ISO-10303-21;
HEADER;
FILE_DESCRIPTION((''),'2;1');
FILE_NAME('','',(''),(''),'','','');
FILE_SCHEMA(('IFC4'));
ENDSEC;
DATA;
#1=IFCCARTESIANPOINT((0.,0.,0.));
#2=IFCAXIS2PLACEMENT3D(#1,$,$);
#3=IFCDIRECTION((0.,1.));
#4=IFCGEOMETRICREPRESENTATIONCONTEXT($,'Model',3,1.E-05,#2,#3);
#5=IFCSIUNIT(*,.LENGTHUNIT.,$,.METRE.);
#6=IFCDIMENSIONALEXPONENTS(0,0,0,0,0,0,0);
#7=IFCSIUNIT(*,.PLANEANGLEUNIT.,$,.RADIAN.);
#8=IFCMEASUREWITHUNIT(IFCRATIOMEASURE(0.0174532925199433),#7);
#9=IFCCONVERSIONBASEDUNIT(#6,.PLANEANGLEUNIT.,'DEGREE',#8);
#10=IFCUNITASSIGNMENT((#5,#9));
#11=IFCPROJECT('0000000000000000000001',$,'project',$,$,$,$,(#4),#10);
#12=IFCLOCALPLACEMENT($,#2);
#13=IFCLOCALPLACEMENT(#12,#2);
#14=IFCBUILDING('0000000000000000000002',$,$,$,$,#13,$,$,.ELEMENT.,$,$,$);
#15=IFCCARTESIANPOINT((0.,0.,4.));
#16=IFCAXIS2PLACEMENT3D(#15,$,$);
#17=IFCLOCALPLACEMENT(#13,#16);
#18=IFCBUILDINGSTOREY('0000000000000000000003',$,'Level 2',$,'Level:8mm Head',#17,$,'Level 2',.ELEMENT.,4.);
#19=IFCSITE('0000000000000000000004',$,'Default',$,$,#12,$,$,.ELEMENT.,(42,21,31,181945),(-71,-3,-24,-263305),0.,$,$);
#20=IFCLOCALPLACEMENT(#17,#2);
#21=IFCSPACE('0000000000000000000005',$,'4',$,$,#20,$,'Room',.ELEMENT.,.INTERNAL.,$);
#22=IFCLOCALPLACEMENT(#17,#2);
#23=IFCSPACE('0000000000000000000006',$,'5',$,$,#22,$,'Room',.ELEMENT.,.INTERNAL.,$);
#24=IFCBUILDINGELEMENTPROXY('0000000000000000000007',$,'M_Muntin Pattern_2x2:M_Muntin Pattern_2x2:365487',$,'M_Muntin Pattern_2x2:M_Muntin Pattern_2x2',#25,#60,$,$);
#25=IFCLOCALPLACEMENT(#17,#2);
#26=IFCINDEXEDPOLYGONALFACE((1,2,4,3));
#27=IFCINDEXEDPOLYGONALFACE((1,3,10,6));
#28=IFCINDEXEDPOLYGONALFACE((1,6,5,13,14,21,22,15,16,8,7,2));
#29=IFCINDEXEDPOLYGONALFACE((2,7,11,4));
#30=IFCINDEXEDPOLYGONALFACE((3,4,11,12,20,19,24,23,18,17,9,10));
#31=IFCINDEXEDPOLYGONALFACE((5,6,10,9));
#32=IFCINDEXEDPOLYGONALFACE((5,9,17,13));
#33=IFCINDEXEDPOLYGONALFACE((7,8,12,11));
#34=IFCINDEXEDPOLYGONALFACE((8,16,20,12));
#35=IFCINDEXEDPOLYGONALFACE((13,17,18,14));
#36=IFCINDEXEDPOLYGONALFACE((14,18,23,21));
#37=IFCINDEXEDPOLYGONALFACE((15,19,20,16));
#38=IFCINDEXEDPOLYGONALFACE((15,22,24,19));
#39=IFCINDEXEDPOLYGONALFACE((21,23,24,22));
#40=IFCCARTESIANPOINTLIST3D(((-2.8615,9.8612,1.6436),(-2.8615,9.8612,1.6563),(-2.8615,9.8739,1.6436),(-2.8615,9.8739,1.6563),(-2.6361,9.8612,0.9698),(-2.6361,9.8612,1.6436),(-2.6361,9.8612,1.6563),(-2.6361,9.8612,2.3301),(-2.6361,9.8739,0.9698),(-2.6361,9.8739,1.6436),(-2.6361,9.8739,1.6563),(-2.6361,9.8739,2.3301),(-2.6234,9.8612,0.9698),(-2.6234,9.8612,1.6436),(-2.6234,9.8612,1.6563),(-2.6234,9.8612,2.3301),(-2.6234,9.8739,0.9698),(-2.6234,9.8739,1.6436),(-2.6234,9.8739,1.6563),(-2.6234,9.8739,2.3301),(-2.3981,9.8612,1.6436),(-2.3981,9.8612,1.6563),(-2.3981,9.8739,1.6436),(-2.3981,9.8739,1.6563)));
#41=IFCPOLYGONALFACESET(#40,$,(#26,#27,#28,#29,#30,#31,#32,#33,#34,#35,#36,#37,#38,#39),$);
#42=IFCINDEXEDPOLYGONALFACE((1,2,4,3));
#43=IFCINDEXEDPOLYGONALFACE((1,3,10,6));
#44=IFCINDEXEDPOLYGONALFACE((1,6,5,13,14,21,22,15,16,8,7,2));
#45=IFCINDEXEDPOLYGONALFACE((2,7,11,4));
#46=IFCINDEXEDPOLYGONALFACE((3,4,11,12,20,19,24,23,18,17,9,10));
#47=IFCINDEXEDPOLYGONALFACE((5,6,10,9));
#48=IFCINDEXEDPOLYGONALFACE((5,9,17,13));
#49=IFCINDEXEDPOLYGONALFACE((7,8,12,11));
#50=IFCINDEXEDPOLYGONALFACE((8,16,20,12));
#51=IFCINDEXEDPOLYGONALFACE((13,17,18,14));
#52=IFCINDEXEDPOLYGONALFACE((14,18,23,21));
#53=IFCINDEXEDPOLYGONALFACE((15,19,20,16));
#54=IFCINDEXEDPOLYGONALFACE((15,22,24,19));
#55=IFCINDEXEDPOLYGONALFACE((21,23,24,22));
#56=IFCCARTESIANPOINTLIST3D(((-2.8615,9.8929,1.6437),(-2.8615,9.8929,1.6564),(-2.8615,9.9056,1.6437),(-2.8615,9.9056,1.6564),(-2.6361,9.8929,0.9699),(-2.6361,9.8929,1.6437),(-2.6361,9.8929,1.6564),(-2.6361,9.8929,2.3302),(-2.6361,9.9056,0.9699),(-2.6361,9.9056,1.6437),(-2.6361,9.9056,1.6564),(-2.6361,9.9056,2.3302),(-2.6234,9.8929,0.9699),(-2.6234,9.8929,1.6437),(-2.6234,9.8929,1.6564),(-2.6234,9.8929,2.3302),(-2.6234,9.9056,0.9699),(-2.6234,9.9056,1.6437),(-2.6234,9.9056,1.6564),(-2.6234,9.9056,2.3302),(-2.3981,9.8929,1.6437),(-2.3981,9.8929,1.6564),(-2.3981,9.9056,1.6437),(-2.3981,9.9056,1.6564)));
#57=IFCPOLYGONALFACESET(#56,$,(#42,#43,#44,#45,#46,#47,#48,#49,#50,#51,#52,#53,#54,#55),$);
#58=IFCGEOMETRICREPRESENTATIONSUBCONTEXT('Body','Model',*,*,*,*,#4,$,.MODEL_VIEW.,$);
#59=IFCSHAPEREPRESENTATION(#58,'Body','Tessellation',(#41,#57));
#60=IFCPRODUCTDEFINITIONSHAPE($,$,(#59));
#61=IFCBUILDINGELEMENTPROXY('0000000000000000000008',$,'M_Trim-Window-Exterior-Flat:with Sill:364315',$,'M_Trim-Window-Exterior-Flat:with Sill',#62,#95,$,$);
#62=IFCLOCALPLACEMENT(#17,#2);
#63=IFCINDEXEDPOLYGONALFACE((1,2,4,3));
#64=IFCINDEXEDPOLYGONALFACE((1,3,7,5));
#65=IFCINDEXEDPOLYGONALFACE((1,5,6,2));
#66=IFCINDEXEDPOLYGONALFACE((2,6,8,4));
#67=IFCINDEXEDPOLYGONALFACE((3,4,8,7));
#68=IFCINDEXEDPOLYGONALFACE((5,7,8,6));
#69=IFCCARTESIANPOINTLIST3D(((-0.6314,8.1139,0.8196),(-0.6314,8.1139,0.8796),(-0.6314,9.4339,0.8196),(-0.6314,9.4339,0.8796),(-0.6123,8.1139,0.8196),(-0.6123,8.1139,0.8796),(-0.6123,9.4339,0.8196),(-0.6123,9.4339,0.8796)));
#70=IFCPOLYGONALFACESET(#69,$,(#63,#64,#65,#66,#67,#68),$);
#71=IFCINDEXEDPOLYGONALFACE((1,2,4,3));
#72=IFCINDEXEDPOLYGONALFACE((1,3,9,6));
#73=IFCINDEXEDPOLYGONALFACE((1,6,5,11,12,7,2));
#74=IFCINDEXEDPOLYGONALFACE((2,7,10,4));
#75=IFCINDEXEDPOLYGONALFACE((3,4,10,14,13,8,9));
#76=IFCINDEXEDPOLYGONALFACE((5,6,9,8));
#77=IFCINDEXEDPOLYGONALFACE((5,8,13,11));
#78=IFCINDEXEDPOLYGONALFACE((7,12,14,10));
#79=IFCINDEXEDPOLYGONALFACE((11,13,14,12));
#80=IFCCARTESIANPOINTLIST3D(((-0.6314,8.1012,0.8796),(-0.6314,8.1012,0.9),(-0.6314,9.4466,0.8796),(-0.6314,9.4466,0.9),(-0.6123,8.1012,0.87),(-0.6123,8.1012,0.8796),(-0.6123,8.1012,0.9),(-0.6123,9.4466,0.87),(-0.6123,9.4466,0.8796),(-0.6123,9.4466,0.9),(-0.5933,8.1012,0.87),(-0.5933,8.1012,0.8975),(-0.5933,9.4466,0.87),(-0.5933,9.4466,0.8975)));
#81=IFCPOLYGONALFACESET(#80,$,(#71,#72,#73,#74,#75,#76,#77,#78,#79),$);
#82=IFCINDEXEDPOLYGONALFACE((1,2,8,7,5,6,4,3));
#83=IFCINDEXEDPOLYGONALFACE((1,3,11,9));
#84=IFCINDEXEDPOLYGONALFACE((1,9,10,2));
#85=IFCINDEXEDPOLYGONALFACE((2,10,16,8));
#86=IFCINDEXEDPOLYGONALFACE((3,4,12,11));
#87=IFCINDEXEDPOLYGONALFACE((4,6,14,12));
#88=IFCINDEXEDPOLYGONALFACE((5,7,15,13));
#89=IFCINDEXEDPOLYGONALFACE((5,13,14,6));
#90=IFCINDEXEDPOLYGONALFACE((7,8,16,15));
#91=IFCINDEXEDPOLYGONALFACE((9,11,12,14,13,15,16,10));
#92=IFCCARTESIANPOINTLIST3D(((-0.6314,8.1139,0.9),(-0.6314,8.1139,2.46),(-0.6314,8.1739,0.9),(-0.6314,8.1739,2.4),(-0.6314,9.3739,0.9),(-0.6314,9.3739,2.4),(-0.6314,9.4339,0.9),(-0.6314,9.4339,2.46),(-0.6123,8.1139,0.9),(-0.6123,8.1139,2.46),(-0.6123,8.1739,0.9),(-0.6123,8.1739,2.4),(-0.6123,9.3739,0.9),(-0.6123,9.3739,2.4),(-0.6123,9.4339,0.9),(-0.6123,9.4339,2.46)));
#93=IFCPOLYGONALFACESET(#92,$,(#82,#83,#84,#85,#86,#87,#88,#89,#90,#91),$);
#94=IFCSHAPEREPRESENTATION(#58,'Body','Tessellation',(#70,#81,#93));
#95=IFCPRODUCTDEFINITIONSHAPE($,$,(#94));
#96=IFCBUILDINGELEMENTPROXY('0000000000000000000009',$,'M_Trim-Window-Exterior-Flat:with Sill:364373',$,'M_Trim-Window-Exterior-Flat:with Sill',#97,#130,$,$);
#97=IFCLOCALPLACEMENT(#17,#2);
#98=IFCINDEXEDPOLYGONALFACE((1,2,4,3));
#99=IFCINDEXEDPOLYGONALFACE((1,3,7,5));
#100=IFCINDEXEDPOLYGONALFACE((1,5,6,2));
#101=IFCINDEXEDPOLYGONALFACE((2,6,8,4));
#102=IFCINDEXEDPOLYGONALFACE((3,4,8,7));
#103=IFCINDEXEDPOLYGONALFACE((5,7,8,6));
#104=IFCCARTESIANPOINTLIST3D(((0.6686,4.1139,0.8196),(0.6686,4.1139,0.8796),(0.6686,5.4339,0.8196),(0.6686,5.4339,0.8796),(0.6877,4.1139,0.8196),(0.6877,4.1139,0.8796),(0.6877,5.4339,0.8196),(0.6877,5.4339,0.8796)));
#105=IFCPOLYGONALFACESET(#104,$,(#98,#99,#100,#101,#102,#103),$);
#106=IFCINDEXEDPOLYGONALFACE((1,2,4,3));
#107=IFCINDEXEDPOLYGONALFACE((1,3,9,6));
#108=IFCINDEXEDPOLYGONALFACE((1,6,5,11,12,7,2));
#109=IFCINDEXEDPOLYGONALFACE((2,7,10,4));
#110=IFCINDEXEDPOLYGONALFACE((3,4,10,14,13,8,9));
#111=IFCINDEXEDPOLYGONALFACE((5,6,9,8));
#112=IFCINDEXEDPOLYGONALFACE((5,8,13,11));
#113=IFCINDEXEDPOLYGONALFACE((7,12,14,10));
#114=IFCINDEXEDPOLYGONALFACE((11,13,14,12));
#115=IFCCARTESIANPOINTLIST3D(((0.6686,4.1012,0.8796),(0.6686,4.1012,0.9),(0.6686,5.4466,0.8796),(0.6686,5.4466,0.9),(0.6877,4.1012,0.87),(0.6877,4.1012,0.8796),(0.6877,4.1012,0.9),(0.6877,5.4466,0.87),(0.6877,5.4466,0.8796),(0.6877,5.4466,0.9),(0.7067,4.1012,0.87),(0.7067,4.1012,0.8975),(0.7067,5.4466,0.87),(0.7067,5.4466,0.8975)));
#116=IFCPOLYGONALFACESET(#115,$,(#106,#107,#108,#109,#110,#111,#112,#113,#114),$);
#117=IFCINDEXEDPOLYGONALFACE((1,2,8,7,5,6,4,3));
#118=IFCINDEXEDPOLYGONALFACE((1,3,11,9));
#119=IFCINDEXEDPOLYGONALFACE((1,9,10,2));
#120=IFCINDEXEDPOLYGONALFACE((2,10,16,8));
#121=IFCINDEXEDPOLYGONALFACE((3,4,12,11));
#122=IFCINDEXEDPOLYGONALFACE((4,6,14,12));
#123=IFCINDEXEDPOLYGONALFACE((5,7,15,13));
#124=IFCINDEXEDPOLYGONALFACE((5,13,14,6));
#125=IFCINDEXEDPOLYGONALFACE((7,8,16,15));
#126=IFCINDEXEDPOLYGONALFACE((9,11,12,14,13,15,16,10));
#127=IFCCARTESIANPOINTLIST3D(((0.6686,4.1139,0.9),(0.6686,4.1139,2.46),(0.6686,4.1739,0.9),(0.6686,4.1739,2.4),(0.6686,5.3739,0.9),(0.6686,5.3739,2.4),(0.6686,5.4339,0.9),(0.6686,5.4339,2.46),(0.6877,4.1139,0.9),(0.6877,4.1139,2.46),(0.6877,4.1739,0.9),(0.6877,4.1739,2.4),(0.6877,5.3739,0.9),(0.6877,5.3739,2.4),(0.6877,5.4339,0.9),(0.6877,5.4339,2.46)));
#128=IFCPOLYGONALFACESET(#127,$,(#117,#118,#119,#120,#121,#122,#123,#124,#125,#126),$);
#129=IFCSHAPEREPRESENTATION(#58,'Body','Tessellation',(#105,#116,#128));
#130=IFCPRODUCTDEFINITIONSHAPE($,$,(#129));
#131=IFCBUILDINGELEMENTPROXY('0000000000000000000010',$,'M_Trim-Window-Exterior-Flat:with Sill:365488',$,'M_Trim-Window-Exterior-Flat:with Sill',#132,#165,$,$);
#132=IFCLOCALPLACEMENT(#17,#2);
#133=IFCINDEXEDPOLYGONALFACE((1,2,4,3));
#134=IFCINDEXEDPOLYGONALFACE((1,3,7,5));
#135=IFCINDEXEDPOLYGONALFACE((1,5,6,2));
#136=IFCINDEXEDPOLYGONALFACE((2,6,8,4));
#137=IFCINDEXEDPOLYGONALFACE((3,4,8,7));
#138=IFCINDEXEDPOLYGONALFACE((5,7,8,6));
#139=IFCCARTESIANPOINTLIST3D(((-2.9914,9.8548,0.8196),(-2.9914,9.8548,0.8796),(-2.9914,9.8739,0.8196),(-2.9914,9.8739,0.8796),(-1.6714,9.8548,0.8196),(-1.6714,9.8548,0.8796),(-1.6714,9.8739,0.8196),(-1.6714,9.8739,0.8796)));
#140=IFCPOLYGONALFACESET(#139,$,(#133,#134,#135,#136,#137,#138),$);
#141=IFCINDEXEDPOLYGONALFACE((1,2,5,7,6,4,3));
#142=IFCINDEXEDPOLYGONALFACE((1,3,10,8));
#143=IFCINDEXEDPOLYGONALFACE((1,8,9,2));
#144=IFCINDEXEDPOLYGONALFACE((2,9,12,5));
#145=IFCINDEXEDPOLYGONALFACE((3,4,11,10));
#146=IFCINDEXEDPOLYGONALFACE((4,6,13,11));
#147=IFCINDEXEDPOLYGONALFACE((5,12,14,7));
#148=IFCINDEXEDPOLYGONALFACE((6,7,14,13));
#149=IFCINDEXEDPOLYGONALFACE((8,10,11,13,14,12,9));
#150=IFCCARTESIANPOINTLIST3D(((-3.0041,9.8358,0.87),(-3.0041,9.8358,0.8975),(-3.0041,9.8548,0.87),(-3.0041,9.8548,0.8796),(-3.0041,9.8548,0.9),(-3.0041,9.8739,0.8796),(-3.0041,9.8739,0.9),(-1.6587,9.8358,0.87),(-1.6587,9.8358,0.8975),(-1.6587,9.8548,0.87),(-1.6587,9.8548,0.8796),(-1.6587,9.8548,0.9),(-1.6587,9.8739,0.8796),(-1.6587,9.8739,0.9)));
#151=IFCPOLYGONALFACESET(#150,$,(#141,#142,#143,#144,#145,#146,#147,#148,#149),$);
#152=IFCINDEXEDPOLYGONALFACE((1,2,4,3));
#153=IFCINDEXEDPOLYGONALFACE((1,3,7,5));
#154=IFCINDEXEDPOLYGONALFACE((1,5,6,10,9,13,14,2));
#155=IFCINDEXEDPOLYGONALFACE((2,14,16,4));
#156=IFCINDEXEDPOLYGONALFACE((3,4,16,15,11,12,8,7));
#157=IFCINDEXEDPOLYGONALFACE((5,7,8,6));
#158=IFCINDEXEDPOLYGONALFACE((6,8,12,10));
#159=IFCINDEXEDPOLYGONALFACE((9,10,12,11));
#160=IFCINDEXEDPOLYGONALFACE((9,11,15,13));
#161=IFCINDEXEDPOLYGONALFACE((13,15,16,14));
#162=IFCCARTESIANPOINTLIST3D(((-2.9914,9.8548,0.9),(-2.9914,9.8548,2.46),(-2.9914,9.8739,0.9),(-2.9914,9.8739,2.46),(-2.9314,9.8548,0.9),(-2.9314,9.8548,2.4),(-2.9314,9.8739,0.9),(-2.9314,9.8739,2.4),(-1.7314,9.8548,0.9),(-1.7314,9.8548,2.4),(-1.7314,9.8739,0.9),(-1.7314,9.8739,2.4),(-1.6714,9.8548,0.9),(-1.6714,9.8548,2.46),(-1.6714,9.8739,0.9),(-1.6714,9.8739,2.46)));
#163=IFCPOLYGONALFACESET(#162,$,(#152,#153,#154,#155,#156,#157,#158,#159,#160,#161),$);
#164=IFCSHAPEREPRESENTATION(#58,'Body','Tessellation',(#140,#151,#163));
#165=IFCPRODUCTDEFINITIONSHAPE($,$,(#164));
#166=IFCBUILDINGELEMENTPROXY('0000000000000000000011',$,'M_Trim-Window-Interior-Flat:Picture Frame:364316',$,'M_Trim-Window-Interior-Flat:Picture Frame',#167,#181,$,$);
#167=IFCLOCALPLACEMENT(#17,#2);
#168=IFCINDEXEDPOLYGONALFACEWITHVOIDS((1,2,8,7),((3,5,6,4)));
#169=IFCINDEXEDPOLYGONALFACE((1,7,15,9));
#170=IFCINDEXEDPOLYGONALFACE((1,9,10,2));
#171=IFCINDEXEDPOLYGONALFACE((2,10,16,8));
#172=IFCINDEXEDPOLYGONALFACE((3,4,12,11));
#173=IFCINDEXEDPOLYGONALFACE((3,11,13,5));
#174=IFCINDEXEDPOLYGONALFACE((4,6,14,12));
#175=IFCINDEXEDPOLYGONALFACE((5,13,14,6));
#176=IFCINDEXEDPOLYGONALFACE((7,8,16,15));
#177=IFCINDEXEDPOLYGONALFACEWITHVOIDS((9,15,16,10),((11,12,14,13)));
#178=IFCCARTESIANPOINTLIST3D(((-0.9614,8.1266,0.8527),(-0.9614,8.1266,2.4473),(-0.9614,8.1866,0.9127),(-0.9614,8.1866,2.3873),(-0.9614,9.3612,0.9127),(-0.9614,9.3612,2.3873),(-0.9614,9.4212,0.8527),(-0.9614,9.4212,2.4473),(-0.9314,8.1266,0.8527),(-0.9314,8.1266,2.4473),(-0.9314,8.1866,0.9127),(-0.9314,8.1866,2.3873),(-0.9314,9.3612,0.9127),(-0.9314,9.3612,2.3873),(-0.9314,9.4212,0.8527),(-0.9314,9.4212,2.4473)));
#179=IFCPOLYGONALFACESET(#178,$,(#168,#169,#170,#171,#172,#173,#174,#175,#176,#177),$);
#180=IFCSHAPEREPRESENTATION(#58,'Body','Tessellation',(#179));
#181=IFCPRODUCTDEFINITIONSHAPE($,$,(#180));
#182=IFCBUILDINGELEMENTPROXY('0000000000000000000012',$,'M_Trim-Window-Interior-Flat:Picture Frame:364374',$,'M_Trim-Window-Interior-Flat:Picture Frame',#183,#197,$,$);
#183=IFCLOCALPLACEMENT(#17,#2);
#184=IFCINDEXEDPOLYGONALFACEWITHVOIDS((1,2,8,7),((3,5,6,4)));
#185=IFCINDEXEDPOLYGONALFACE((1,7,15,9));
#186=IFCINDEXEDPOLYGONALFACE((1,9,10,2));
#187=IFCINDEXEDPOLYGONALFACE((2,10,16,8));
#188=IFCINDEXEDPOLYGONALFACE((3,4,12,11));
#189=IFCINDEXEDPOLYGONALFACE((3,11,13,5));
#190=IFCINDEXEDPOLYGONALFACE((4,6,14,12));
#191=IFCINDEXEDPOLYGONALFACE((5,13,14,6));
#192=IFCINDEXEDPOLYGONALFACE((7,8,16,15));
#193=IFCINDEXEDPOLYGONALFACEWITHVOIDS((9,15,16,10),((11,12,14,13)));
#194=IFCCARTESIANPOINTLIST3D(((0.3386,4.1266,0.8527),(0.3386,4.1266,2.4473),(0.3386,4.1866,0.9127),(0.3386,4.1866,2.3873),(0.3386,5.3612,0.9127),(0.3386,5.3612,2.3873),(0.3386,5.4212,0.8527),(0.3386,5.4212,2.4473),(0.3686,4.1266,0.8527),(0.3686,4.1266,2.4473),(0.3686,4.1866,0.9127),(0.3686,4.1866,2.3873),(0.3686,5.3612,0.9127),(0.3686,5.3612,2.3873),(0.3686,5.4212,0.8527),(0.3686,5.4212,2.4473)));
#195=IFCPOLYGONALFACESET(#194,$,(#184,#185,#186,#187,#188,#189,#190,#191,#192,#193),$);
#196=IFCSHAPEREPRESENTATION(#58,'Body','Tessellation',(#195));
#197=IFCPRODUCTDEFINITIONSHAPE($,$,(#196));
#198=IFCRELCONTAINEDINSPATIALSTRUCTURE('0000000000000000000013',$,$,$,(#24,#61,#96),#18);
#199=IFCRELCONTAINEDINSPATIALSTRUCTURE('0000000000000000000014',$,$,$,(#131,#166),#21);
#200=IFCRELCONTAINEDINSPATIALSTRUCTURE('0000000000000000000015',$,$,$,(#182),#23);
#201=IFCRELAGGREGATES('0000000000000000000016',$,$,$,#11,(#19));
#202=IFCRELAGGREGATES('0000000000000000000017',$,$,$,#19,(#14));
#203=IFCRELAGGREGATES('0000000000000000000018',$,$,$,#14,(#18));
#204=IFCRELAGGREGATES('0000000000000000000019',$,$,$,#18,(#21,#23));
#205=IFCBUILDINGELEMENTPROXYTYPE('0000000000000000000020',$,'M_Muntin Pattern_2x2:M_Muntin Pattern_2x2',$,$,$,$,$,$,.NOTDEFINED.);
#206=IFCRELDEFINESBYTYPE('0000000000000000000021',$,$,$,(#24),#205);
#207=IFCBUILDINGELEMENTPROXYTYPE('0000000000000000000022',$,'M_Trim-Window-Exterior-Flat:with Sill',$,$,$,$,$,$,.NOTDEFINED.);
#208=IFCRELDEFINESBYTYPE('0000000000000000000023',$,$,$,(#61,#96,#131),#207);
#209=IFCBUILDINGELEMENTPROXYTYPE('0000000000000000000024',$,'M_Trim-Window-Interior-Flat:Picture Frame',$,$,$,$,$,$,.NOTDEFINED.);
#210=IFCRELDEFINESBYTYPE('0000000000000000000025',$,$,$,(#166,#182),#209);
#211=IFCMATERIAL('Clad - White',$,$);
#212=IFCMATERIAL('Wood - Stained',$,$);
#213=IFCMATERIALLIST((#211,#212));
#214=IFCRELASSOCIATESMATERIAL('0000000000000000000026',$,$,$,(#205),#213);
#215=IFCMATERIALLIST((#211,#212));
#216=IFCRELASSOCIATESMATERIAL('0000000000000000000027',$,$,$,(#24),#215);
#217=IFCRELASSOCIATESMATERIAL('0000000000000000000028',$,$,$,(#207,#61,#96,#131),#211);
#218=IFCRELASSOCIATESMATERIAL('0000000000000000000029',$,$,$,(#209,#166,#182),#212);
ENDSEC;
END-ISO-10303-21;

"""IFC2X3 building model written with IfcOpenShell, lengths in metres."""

from ifc_helpers import new_model, entity, si_unit, converted_unit, direction, frame, frame_2d, origin, place, context, subcontext, project, spatial, polyline, rectangle, outline, extrude, source, transform, mapped, material, material_list, type_object, type_shapes, element, save


model = new_model("IFC2X3")

# Units and contexts
model_context = context("Model", 3, precision=1e-05, world=origin(), true_north=direction((0.0, 1.0)))
body_context = subcontext(model_context, "Body", "Model", "MODEL_VIEW")
ifc_project = project(units=[si_unit("LENGTHUNIT", "METRE"), converted_unit("PLANEANGLEUNIT", "DEGREE", entity("IfcRatioMeasure", 0.0174532925199433), si_unit("PLANEANGLEUNIT", "RADIAN"), dimensions=[0, 0, 0, 0, 0, 0, 0])], contexts=[model_context])

# Site, building, storey
site_placement = place(None, origin())
site = spatial("IfcSite", under=ifc_project, at=site_placement, Name="Default", CompositionType="ELEMENT", RefLatitude=(42, 21, 31, 181945), RefLongitude=(-71, -3, -24, -263305), RefElevation=0.0)
building_placement = place(site_placement, origin())
building = spatial("IfcBuilding", under=site, at=building_placement, CompositionType="ELEMENT")
storey_placement = place(building_placement, frame((0.0, 0.0, 4.0)))
storey = spatial("IfcBuildingStorey", under=building, at=storey_placement, Name="Level 2", ObjectType="Level:8mm Head", LongName="Level 2", CompositionType="ELEMENT", Elevation=4.0)

# Building element proxies
ifc_material_1 = material(Name="Clad - White")
ifc_material_2 = material(Name="Wood - Stained")
ifc_material_list_1 = material_list([ifc_material_1, ifc_material_2])
building_element_proxy_type_1 = type_object("IfcBuildingElementProxyType", Name="M_Muntin Pattern_2x2:M_Muntin Pattern_2x2", PredefinedType="NOTDEFINED", material=ifc_material_list_1)
shared_shape_1 = source(origin(), body_context, "Body", "SweptSolid", [
    extrude(outline(polyline([(0.0064, -0.0064), (0.6801, -0.0064), (0.6801, 0.0063), (0.0064, 0.0063), (0.0064, 0.2317), (-0.0063, 0.2317), (-0.0063, 0.0063), (-0.6802, 0.0063), (-0.6802, -0.0064), (-0.0063, -0.0064), (-0.0063, -0.2317), (0.0064, -0.2317), (0.0064, -0.0064)])), frame((0.0, -0.0222, 0.6801), z_axis=(0.0, 1.0, 0.0), x_axis=(0.0, 0.0, 1.0)), (0.0, 0.0, 1.0), 0.0127),
    extrude(outline(polyline([(0.0064, -0.0064), (0.6802, -0.0064), (0.6802, 0.0063), (0.0064, 0.0063), (0.0064, 0.2317), (-0.0063, 0.2317), (-0.0063, 0.0063), (-0.6802, 0.0063), (-0.6802, -0.0064), (-0.0063, -0.0064), (-0.0063, -0.2317), (0.0064, -0.2317), (0.0064, -0.0064)])), frame((0.0, 0.0095, 0.6802), z_axis=(0.0, 1.0, 0.0), x_axis=(0.0, 0.0, 1.0)), (0.0, 0.0, 1.0), 0.0127),
])
type_shapes(building_element_proxy_type_1, [shared_shape_1])
ifc_material_list_2 = material_list([ifc_material_1, ifc_material_2])
proxy_1_placement = place(storey_placement, frame((-2.6298, 9.8834, 0.9699)))
element("IfcBuildingElementProxy", 1, at=proxy_1_placement, inside=storey, type_object=building_element_proxy_type_1, material=ifc_material_list_2, Name="M_Muntin Pattern_2x2:M_Muntin Pattern_2x2:365487", ObjectType="M_Muntin Pattern_2x2:M_Muntin Pattern_2x2", context=body_context, shape_type="MappedRepresentation", body=[
    mapped(shared_shape_1, transform((0.0, 0.0, 0.0), scale=1.0)),
])
building_element_proxy_type_2 = type_object("IfcBuildingElementProxyType", Name="M_Trim-Window-Exterior-Flat:with Sill", PredefinedType="NOTDEFINED", material=ifc_material_1)
shared_shape_2 = source(origin(), body_context, "Body", "SweptSolid", [
    extrude(rectangle(XDim=1.32, YDim=0.06, at=frame_2d((0.0, 0.0), x_axis=(1.0, 0.0))), frame((0.0, -1.5504, 0.0), z_axis=(0.0, 0.0, 1.0), x_axis=(-1.0, 0.0, 0.0)), (0.0, 0.0, 1.0), 0.0191),
    extrude(outline(polyline([(-0.019, -0.0152), (0.0, -0.0152), (0.0, -0.0057), (0.019, -0.0057), (0.019, 0.0148), (0.0, 0.0148), (-0.019, 0.0123), (-0.019, -0.0152)])), frame((-0.6727, -1.5148, 0.019), z_axis=(1.0, 0.0, 0.0), x_axis=(0.0, 0.0, -1.0)), (0.0, 0.0, 1.0), 1.3454),
    extrude(outline(polyline([(-0.795, -0.66), (0.765, -0.66), (0.765, -0.6), (-0.735, -0.6), (-0.735, 0.6), (0.765, 0.6), (0.765, 0.66), (-0.795, 0.66), (-0.795, -0.66)])), frame((0.0, -0.735, 0.0), z_axis=(0.0, 0.0, 1.0), x_axis=(0.0, -1.0, 0.0)), (0.0, 0.0, 1.0), 0.0191),
])
type_shapes(building_element_proxy_type_2, [shared_shape_2])
for number, where, z_axis, x_axis, name in (
    (2, (-0.6314, 8.7739, 2.4), (1.0, 0.0, 0.0), (0.0, 1.0, 0.0), "M_Trim-Window-Exterior-Flat:with Sill:364315"),
    (3, (0.6686, 4.7739, 2.4), (1.0, 0.0, 0.0), (0.0, 1.0, 0.0), "M_Trim-Window-Exterior-Flat:with Sill:364373"),
):
    element("IfcBuildingElementProxy", number, at=place(storey_placement, frame(where, z_axis=z_axis, x_axis=x_axis)), inside=storey, type_object=building_element_proxy_type_2, material=ifc_material_1, Name=name, ObjectType="M_Trim-Window-Exterior-Flat:with Sill", context=body_context, shape_type="MappedRepresentation", body=[
        mapped(shared_shape_2, transform((0.0, 0.0, 0.0), scale=1.0)),
    ])

# Shared definitions
space_1_placement = place(storey_placement, origin())
space_1 = spatial("IfcSpace", under=storey, at=space_1_placement, Name="4", LongName="Room", CompositionType="ELEMENT", InteriorOrExteriorSpace="INTERNAL")

# Building element proxies
proxy_2_placement = place(space_1_placement, frame((-2.3314, 9.8739, 2.4), z_axis=(0.0, -1.0, 0.0), x_axis=(1.0, 0.0, 0.0)))
element("IfcBuildingElementProxy", 4, at=proxy_2_placement, inside=space_1, type_object=building_element_proxy_type_2, material=ifc_material_1, Name="M_Trim-Window-Exterior-Flat:with Sill:365488", ObjectType="M_Trim-Window-Exterior-Flat:with Sill", context=body_context, shape_type="MappedRepresentation", body=[
    mapped(shared_shape_2, transform((0.0, 0.0, 0.0), scale=1.0)),
])
building_element_proxy_type_3 = type_object("IfcBuildingElementProxyType", Name="M_Trim-Window-Interior-Flat:Picture Frame", PredefinedType="NOTDEFINED", material=ifc_material_2)
shared_shape_3 = source(origin(), body_context, "Body", "SweptSolid", [
    extrude(outline(polyline([(-0.6473, -0.7973), (0.6473, -0.7973), (0.6473, 0.7973), (-0.6473, 0.7973), (-0.6473, -0.7973)]), holes=[polyline([(-0.5873, -0.7373), (-0.5873, 0.7373), (0.5873, 0.7373), (0.5873, -0.7373), (-0.5873, -0.7373)])]), frame((0.0, -0.75, 0.0), z_axis=(0.0, 0.0, 1.0), x_axis=(-1.0, 0.0, 0.0)), (0.0, 0.0, 1.0), 0.03),
])
type_shapes(building_element_proxy_type_3, [shared_shape_3])
proxy_3_placement = place(space_1_placement, frame((-0.9314, 8.7739, 2.4), z_axis=(-1.0, 0.0, 0.0), x_axis=(0.0, -1.0, 0.0)))
element("IfcBuildingElementProxy", 5, at=proxy_3_placement, inside=space_1, type_object=building_element_proxy_type_3, material=ifc_material_2, Name="M_Trim-Window-Interior-Flat:Picture Frame:364316", ObjectType="M_Trim-Window-Interior-Flat:Picture Frame", context=body_context, shape_type="MappedRepresentation", body=[
    mapped(shared_shape_3, transform((0.0, 0.0, 0.0), scale=1.0)),
])

# Shared definitions
space_2_placement = place(storey_placement, origin())
space_2 = spatial("IfcSpace", under=storey, at=space_2_placement, Name="5", LongName="Room", CompositionType="ELEMENT", InteriorOrExteriorSpace="INTERNAL")

# Building element proxy
proxy_4_placement = place(space_2_placement, frame((0.3686, 4.7739, 2.4), z_axis=(-1.0, 0.0, 0.0), x_axis=(0.0, -1.0, 0.0)))
element("IfcBuildingElementProxy", 6, at=proxy_4_placement, inside=space_2, type_object=building_element_proxy_type_3, material=ifc_material_2, Name="M_Trim-Window-Interior-Flat:Picture Frame:364374", ObjectType="M_Trim-Window-Interior-Flat:Picture Frame", context=body_context, shape_type="MappedRepresentation", body=[
    mapped(shared_shape_3, transform((0.0, 0.0, 0.0), scale=1.0)),
])

save(model, "model.ifc")
